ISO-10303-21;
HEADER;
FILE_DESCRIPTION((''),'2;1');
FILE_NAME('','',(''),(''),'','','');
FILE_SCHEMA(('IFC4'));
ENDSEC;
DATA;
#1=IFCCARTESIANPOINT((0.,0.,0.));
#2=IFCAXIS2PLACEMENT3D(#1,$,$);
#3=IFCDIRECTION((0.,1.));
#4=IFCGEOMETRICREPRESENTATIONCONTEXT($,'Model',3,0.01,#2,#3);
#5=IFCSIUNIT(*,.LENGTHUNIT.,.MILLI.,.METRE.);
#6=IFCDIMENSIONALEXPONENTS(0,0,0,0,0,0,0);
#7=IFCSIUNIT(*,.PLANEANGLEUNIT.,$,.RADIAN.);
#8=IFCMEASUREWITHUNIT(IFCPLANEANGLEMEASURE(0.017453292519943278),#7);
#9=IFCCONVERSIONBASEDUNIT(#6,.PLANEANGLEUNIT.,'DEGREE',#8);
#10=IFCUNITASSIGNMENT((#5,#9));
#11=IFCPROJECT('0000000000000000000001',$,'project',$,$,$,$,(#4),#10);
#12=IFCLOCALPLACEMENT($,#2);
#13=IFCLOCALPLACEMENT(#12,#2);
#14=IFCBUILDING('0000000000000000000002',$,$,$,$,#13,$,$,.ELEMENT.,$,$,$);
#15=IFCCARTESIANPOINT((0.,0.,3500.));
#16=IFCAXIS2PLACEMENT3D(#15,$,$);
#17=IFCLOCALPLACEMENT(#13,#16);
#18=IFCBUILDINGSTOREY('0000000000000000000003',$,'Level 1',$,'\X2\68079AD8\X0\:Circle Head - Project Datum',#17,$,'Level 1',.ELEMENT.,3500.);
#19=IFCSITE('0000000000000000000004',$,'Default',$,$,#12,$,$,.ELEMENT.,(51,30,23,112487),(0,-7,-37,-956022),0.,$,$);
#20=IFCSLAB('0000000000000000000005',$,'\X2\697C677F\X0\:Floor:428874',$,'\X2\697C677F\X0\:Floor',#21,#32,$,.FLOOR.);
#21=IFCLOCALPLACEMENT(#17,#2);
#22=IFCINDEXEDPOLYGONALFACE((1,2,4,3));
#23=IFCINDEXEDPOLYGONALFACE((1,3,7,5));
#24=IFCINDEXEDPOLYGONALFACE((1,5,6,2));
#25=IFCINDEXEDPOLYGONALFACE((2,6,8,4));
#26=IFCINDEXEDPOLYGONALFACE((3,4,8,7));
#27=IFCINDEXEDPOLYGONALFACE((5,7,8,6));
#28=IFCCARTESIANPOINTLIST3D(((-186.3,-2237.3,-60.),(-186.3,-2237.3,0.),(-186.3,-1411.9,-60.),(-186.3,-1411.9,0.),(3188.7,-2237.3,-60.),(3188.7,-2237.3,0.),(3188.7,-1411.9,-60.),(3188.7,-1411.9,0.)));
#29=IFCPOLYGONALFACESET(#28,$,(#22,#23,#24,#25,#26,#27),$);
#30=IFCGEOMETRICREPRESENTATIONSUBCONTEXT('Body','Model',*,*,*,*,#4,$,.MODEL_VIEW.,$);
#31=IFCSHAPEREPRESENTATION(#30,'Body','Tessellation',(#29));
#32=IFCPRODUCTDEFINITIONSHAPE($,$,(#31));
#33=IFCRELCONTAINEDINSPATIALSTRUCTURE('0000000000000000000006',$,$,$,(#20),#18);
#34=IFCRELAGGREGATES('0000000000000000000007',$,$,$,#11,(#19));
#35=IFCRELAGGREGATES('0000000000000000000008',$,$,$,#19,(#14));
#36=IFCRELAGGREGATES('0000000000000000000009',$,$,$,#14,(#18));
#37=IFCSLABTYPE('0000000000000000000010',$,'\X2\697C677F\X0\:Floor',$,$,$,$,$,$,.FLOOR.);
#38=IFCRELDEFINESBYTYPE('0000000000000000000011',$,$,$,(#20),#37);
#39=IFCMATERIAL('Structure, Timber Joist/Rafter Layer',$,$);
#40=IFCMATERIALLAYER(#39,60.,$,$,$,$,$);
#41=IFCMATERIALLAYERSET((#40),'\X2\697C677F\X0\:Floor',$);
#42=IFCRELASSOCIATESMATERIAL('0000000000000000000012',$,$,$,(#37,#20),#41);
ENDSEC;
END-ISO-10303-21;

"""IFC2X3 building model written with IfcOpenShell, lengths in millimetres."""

from ifc_helpers import new_model, entity, si_unit, converted_unit, direction, frame, frame_2d, origin, place, context, subcontext, project, spatial, rectangle, extrude, material, layer, layer_set, layer_usage, type_object, element, save


model = new_model("IFC2X3")

# Units and contexts
model_context = context("Model", 3, precision=0.01, world=origin(), true_north=direction((0.0, 1.0)))
body_context = subcontext(model_context, "Body", "Model", "MODEL_VIEW")
ifc_project = project(units=[si_unit("LENGTHUNIT", "METRE", prefix="MILLI"), converted_unit("PLANEANGLEUNIT", "DEGREE", entity("IfcPlaneAngleMeasure", 0.017453292519943278), si_unit("PLANEANGLEUNIT", "RADIAN"), dimensions=[0, 0, 0, 0, 0, 0, 0])], contexts=[model_context])

# Site, building, storey
site_placement = place(None, origin())
site = spatial("IfcSite", under=ifc_project, at=site_placement, Name="Default", CompositionType="ELEMENT", RefLatitude=(51, 30, 23, 112487), RefLongitude=(0, -7, -37, -956022), RefElevation=0.0)
building_placement = place(site_placement, origin())
building = spatial("IfcBuilding", under=site, at=building_placement, CompositionType="ELEMENT")
storey_placement = place(building_placement, frame((0.0, 0.0, 3500.0)))
storey = spatial("IfcBuildingStorey", under=building, at=storey_placement, Name="Level 1", ObjectType="标高:Circle Head - Project Datum", LongName="Level 1", CompositionType="ELEMENT", Elevation=3500.0)

# Slab
ifc_material_1 = material(Name="Structure, Timber Joist/Rafter Layer")
ifc_layer = layer(ifc_material_1, 60.0)
ifc_layer_set = layer_set([ifc_layer], Name="楼板:Floor")
slab_type = type_object("IfcSlabType", Name="楼板:Floor", PredefinedType="FLOOR", material=ifc_layer_set)
ifc_layer_usage_1 = layer_usage(ifc_layer_set, "AXIS3", "POSITIVE", 0.0)
slab_1_placement = place(storey_placement, origin())
element("IfcSlab", 1, at=slab_1_placement, inside=storey, type_object=slab_type, material=ifc_layer_usage_1, Name="楼板:Floor:428874", ObjectType="楼板:Floor", PredefinedType="FLOOR", context=body_context, shape_type="SweptSolid", body=[
    extrude(rectangle(XDim=825.4, YDim=3375.0, at=frame_2d((0.0, 0.0), x_axis=(1.0, 0.0))), frame((1501.2, -1824.6, 0.0), z_axis=(0.0, 0.0, -1.0), x_axis=(0.0, 1.0, 0.0)), (0.0, 0.0, 1.0), 60.0),
])

save(model, "model.ifc")
